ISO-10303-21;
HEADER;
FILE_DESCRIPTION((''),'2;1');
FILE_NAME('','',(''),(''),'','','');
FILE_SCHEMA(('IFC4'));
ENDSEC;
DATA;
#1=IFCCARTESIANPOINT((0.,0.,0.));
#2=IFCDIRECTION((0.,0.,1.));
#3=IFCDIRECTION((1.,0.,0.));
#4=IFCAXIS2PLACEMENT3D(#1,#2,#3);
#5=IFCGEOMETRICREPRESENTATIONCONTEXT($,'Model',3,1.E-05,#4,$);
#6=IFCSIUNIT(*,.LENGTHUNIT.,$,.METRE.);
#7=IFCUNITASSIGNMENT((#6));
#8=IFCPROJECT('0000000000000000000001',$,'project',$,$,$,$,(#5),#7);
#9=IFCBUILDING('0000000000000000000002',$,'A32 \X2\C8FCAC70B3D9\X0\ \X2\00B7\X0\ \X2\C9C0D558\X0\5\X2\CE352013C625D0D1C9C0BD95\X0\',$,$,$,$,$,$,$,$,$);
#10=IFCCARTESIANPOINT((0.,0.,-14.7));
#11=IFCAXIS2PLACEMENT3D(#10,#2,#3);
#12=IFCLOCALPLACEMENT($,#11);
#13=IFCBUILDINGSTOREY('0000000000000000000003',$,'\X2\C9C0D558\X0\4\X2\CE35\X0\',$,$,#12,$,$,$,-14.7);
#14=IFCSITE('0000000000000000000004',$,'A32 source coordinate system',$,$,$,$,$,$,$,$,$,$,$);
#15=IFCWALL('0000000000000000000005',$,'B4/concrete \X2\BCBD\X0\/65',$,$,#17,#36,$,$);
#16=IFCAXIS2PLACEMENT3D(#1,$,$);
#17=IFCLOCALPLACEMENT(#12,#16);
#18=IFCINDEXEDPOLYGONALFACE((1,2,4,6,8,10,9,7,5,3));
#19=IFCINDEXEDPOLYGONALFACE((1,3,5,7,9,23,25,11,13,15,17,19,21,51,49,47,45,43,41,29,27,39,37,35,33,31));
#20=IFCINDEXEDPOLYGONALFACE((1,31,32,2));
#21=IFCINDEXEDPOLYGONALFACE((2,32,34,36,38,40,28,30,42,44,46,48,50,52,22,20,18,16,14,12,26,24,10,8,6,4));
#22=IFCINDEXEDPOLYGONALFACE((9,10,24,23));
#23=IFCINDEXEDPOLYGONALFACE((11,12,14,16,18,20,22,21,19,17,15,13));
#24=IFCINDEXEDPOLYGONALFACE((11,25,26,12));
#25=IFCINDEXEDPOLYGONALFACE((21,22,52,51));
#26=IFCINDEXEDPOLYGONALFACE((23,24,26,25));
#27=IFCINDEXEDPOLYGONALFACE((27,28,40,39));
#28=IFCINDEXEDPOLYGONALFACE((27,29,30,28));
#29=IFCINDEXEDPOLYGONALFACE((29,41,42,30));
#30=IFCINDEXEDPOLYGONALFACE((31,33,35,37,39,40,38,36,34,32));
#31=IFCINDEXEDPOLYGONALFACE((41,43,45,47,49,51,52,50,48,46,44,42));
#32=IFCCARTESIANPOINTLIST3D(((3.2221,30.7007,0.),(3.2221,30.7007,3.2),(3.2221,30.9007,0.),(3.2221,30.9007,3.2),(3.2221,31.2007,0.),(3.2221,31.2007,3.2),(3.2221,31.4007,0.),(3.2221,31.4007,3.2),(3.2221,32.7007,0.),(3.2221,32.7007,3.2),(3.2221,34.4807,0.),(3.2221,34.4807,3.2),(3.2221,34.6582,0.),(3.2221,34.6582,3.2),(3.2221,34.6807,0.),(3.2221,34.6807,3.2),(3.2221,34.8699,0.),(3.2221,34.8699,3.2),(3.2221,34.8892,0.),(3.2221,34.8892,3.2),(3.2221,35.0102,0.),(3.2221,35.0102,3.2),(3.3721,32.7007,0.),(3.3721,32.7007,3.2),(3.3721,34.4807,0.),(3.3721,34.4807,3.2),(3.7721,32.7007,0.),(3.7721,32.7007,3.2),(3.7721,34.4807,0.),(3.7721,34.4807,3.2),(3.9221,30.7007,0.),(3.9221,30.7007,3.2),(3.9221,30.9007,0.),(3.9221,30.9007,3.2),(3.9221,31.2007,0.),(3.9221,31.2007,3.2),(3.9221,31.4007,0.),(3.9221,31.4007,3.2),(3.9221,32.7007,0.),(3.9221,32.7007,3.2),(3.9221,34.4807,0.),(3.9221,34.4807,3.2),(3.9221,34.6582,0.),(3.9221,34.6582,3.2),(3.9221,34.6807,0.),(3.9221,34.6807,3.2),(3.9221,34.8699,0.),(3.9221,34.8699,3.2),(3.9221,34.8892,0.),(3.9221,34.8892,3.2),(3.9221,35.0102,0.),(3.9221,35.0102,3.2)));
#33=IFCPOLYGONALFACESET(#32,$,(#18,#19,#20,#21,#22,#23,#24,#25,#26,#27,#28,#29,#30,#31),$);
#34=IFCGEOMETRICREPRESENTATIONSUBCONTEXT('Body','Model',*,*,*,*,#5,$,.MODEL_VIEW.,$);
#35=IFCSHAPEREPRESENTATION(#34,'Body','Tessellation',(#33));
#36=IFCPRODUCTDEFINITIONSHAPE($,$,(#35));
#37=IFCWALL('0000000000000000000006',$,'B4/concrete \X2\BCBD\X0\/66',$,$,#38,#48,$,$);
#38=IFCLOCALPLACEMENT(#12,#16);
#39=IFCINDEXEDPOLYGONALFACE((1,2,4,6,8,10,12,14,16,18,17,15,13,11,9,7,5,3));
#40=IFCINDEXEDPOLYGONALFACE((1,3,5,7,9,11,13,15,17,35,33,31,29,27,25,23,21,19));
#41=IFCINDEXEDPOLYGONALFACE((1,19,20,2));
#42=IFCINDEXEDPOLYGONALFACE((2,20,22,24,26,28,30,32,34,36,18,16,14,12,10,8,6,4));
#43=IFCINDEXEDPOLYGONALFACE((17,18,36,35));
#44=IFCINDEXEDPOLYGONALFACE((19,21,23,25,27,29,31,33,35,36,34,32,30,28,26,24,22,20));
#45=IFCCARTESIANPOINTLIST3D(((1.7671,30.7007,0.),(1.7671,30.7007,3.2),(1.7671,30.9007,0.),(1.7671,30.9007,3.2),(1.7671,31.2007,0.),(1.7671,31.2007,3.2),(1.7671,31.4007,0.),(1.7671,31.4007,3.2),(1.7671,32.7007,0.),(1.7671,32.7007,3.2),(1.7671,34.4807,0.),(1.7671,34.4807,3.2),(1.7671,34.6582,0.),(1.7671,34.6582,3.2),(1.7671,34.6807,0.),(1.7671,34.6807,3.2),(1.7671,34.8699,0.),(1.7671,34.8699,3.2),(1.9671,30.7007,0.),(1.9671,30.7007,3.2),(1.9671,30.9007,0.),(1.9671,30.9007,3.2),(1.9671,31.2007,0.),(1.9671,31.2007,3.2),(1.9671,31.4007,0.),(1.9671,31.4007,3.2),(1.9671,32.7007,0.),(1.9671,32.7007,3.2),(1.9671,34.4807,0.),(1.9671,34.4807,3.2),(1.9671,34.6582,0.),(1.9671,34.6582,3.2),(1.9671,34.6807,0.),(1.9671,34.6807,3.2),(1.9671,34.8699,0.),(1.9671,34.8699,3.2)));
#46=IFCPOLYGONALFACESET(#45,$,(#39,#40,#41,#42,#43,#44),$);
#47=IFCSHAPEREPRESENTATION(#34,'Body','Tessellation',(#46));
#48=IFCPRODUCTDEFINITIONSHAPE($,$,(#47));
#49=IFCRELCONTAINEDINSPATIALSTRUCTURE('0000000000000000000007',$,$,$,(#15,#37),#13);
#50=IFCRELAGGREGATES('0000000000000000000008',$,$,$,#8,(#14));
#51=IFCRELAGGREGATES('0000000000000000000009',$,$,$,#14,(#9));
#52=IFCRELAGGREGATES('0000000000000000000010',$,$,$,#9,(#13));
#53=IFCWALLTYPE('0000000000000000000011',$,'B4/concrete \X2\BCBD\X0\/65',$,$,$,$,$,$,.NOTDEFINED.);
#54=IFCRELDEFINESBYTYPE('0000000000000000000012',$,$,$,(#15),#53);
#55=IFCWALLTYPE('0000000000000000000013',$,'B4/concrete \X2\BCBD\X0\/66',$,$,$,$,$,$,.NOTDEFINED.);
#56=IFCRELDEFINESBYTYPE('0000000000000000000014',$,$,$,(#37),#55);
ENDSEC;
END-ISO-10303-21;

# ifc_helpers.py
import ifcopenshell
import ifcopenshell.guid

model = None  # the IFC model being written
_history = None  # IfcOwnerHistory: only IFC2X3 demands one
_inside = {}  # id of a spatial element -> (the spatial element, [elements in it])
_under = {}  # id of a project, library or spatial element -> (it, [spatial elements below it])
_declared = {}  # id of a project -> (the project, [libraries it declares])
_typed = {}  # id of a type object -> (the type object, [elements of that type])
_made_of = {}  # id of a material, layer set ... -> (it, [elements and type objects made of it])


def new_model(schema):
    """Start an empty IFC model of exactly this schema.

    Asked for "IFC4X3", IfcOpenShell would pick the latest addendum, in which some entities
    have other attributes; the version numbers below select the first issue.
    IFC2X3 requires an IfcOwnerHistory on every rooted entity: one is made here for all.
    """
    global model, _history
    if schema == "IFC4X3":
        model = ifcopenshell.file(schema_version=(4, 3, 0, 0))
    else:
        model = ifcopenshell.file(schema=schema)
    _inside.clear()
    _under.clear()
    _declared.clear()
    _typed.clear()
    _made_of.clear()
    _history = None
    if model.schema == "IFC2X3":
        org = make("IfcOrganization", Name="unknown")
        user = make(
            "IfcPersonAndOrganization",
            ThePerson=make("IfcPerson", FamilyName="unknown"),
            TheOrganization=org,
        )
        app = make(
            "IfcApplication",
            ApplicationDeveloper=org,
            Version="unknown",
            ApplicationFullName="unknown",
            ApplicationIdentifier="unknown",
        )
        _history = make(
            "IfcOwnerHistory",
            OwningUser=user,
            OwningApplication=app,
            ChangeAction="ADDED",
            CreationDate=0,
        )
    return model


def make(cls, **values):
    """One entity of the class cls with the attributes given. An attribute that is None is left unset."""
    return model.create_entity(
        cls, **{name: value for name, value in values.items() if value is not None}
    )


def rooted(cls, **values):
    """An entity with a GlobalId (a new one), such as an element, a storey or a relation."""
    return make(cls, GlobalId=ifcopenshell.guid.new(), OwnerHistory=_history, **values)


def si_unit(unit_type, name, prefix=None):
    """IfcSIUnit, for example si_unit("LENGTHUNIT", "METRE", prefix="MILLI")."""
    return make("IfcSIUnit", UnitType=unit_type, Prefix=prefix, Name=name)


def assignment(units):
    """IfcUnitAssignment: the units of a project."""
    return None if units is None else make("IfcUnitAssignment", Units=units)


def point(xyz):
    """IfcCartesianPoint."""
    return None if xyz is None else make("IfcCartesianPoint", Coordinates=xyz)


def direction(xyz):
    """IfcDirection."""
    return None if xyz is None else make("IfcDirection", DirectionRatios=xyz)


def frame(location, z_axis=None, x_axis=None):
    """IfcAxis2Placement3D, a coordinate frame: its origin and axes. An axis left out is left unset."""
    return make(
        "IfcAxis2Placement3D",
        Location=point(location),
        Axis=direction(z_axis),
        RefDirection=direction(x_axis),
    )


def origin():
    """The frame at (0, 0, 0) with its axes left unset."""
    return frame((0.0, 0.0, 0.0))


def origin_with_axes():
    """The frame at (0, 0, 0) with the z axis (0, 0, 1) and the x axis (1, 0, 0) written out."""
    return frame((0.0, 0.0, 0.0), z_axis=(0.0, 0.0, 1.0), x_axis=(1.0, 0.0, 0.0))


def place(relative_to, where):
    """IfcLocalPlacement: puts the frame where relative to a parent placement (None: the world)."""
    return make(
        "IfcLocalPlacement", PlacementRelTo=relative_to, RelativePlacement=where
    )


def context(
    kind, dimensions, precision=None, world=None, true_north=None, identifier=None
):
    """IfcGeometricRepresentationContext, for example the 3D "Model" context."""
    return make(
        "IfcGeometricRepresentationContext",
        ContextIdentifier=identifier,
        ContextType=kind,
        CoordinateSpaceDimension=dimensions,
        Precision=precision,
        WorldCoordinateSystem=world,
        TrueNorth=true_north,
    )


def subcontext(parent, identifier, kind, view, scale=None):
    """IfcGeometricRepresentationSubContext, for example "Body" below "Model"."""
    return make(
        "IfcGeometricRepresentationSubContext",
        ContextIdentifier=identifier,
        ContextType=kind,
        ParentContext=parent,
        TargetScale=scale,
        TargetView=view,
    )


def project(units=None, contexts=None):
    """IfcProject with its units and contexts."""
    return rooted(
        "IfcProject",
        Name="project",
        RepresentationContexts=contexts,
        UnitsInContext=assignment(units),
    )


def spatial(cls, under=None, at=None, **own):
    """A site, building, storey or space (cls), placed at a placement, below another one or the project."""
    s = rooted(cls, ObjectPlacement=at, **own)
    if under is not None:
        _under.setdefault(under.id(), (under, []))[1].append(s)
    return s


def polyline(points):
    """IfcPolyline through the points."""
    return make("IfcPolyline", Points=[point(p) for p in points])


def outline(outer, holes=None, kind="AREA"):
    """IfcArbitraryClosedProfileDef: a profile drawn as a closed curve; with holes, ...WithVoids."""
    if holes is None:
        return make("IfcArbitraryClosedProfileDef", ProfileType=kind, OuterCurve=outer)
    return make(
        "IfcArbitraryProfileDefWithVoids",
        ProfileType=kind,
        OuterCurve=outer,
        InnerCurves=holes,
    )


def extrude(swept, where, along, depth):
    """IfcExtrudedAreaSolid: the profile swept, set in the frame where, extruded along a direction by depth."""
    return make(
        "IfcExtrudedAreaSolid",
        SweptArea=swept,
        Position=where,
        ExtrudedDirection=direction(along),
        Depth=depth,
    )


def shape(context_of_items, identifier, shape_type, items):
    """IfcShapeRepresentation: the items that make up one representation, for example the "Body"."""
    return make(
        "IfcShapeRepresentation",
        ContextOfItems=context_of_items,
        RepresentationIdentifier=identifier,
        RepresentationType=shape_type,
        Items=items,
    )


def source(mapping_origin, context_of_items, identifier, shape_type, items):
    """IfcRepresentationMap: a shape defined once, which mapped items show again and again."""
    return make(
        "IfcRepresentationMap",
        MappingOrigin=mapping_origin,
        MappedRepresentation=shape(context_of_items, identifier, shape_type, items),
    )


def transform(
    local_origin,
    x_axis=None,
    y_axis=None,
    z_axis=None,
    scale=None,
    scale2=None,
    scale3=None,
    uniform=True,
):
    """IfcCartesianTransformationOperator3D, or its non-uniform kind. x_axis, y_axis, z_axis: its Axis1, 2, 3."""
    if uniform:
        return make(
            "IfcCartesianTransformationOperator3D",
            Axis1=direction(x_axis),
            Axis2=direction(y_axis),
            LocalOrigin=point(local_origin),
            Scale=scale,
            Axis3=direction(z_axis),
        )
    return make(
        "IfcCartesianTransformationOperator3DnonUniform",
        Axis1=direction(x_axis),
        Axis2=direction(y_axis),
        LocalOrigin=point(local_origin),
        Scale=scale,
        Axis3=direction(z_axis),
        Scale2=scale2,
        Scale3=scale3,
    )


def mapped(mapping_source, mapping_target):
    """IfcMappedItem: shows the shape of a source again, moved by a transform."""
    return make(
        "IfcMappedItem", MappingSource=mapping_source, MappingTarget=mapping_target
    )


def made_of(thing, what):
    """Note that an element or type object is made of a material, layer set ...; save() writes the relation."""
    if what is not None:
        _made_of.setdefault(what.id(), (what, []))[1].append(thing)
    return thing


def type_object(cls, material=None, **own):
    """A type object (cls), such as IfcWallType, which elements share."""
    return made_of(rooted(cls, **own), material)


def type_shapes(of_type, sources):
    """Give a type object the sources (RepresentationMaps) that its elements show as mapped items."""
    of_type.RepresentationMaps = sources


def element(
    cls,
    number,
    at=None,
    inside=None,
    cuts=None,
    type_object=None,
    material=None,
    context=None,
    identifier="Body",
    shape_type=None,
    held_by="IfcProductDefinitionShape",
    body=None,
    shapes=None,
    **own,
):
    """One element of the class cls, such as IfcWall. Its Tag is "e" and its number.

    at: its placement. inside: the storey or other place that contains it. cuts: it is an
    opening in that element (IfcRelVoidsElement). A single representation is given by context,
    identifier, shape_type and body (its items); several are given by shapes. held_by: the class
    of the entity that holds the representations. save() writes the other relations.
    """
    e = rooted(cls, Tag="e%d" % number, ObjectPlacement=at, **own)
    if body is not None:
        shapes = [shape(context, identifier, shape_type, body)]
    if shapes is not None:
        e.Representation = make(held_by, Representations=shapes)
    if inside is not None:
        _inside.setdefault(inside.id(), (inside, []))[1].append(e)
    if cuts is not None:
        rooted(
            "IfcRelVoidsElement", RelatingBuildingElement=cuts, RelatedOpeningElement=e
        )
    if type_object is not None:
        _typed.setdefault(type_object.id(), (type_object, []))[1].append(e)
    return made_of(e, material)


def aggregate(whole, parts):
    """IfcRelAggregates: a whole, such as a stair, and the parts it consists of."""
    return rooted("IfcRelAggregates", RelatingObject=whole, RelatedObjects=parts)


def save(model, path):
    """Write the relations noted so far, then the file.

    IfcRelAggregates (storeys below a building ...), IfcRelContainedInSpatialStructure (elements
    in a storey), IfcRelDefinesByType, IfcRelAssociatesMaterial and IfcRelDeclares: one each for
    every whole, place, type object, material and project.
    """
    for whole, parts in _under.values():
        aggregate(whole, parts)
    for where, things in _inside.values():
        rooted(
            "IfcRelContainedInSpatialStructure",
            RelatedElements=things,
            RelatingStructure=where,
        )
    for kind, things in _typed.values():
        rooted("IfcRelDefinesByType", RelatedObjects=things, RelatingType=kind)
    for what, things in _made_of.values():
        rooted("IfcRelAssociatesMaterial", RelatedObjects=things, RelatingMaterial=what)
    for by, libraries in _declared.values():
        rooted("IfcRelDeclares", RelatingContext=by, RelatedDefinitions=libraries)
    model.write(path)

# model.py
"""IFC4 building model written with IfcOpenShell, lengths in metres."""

from ifc_helpers import new_model, si_unit, frame, origin, origin_with_axes, place, context, subcontext, project, spatial, polyline, outline, extrude, source, transform, mapped, type_object, type_shapes, element, save


model = new_model("IFC4")

# Units and contexts
model_context = context("Model", 3, precision=1e-05, world=origin_with_axes())
body_context = subcontext(model_context, "Body", "Model", "MODEL_VIEW")
ifc_project = project(units=[si_unit("LENGTHUNIT", "METRE")], contexts=[model_context])

# Site, building, storey
site = spatial("IfcSite", under=ifc_project, Name="A32 source coordinate system")
building = spatial("IfcBuilding", under=site, Name="A32 주거동 · 지하5층–옥탑지붕")
storey_placement = place(None, frame((0.0, 0.0, -14.7), z_axis=(0.0, 0.0, 1.0), x_axis=(1.0, 0.0, 0.0)))
storey = spatial("IfcBuildingStorey", under=building, at=storey_placement, Name="지하4층", Elevation=-14.7)

# Walls
wall_type_1 = type_object("IfcWallType", Name="B4/concrete 벽/65", PredefinedType="NOTDEFINED")
shared_shape_1 = source(origin(), body_context, "Body", "SweptSolid", [
    extrude(outline(polyline([(3.3721, 32.7007), (3.3721, 34.4807), (3.2221, 34.4807), (3.2221, 34.6582), (3.2221, 34.6807), (3.2221, 34.8699), (3.2221, 34.8892), (3.2221, 35.0102), (3.9221, 35.0102), (3.9221, 34.8892), (3.9221, 34.8699), (3.9221, 34.6807), (3.9221, 34.6582), (3.9221, 34.4807), (3.7721, 34.4807), (3.7721, 32.7007), (3.9221, 32.7007), (3.9221, 31.4007), (3.9221, 31.2007), (3.9221, 30.9007), (3.9221, 30.7007), (3.2221, 30.7007), (3.2221, 30.9007), (3.2221, 31.2007), (3.2221, 31.4007), (3.2221, 32.7007), (3.3721, 32.7007)])), origin(), (0.0, 0.0, 1.0), 3.2),
])
type_shapes(wall_type_1, [shared_shape_1])
wall_1_placement = place(storey_placement, origin_with_axes())
element("IfcWall", 1, at=wall_1_placement, inside=storey, type_object=wall_type_1, Name="B4/concrete 벽/65", context=body_context, shape_type="MappedRepresentation", body=[
    mapped(shared_shape_1, transform((0.0, 0.0, 0.0), scale=1.0)),
])
wall_type_2 = type_object("IfcWallType", Name="B4/concrete 벽/66", PredefinedType="NOTDEFINED")
shared_shape_2 = source(origin(), body_context, "Body", "SweptSolid", [
    extrude(outline(polyline([(1.7671, 34.6807), (1.7671, 34.8699), (1.9671, 34.8699), (1.9671, 34.6807), (1.9671, 34.6582), (1.9671, 34.4807), (1.9671, 32.7007), (1.9671, 31.4007), (1.9671, 31.2007), (1.9671, 30.9007), (1.9671, 30.7007), (1.7671, 30.7007), (1.7671, 30.9007), (1.7671, 31.2007), (1.7671, 31.4007), (1.7671, 32.7007), (1.7671, 34.4807), (1.7671, 34.6582), (1.7671, 34.6807)])), origin(), (0.0, 0.0, 1.0), 3.2),
])
type_shapes(wall_type_2, [shared_shape_2])
wall_2_placement = place(storey_placement, origin_with_axes())
element("IfcWall", 2, at=wall_2_placement, inside=storey, type_object=wall_type_2, Name="B4/concrete 벽/66", context=body_context, shape_type="MappedRepresentation", body=[
    mapped(shared_shape_2, transform((0.0, 0.0, 0.0), scale=1.0)),
])

save(model, "model.ifc")
